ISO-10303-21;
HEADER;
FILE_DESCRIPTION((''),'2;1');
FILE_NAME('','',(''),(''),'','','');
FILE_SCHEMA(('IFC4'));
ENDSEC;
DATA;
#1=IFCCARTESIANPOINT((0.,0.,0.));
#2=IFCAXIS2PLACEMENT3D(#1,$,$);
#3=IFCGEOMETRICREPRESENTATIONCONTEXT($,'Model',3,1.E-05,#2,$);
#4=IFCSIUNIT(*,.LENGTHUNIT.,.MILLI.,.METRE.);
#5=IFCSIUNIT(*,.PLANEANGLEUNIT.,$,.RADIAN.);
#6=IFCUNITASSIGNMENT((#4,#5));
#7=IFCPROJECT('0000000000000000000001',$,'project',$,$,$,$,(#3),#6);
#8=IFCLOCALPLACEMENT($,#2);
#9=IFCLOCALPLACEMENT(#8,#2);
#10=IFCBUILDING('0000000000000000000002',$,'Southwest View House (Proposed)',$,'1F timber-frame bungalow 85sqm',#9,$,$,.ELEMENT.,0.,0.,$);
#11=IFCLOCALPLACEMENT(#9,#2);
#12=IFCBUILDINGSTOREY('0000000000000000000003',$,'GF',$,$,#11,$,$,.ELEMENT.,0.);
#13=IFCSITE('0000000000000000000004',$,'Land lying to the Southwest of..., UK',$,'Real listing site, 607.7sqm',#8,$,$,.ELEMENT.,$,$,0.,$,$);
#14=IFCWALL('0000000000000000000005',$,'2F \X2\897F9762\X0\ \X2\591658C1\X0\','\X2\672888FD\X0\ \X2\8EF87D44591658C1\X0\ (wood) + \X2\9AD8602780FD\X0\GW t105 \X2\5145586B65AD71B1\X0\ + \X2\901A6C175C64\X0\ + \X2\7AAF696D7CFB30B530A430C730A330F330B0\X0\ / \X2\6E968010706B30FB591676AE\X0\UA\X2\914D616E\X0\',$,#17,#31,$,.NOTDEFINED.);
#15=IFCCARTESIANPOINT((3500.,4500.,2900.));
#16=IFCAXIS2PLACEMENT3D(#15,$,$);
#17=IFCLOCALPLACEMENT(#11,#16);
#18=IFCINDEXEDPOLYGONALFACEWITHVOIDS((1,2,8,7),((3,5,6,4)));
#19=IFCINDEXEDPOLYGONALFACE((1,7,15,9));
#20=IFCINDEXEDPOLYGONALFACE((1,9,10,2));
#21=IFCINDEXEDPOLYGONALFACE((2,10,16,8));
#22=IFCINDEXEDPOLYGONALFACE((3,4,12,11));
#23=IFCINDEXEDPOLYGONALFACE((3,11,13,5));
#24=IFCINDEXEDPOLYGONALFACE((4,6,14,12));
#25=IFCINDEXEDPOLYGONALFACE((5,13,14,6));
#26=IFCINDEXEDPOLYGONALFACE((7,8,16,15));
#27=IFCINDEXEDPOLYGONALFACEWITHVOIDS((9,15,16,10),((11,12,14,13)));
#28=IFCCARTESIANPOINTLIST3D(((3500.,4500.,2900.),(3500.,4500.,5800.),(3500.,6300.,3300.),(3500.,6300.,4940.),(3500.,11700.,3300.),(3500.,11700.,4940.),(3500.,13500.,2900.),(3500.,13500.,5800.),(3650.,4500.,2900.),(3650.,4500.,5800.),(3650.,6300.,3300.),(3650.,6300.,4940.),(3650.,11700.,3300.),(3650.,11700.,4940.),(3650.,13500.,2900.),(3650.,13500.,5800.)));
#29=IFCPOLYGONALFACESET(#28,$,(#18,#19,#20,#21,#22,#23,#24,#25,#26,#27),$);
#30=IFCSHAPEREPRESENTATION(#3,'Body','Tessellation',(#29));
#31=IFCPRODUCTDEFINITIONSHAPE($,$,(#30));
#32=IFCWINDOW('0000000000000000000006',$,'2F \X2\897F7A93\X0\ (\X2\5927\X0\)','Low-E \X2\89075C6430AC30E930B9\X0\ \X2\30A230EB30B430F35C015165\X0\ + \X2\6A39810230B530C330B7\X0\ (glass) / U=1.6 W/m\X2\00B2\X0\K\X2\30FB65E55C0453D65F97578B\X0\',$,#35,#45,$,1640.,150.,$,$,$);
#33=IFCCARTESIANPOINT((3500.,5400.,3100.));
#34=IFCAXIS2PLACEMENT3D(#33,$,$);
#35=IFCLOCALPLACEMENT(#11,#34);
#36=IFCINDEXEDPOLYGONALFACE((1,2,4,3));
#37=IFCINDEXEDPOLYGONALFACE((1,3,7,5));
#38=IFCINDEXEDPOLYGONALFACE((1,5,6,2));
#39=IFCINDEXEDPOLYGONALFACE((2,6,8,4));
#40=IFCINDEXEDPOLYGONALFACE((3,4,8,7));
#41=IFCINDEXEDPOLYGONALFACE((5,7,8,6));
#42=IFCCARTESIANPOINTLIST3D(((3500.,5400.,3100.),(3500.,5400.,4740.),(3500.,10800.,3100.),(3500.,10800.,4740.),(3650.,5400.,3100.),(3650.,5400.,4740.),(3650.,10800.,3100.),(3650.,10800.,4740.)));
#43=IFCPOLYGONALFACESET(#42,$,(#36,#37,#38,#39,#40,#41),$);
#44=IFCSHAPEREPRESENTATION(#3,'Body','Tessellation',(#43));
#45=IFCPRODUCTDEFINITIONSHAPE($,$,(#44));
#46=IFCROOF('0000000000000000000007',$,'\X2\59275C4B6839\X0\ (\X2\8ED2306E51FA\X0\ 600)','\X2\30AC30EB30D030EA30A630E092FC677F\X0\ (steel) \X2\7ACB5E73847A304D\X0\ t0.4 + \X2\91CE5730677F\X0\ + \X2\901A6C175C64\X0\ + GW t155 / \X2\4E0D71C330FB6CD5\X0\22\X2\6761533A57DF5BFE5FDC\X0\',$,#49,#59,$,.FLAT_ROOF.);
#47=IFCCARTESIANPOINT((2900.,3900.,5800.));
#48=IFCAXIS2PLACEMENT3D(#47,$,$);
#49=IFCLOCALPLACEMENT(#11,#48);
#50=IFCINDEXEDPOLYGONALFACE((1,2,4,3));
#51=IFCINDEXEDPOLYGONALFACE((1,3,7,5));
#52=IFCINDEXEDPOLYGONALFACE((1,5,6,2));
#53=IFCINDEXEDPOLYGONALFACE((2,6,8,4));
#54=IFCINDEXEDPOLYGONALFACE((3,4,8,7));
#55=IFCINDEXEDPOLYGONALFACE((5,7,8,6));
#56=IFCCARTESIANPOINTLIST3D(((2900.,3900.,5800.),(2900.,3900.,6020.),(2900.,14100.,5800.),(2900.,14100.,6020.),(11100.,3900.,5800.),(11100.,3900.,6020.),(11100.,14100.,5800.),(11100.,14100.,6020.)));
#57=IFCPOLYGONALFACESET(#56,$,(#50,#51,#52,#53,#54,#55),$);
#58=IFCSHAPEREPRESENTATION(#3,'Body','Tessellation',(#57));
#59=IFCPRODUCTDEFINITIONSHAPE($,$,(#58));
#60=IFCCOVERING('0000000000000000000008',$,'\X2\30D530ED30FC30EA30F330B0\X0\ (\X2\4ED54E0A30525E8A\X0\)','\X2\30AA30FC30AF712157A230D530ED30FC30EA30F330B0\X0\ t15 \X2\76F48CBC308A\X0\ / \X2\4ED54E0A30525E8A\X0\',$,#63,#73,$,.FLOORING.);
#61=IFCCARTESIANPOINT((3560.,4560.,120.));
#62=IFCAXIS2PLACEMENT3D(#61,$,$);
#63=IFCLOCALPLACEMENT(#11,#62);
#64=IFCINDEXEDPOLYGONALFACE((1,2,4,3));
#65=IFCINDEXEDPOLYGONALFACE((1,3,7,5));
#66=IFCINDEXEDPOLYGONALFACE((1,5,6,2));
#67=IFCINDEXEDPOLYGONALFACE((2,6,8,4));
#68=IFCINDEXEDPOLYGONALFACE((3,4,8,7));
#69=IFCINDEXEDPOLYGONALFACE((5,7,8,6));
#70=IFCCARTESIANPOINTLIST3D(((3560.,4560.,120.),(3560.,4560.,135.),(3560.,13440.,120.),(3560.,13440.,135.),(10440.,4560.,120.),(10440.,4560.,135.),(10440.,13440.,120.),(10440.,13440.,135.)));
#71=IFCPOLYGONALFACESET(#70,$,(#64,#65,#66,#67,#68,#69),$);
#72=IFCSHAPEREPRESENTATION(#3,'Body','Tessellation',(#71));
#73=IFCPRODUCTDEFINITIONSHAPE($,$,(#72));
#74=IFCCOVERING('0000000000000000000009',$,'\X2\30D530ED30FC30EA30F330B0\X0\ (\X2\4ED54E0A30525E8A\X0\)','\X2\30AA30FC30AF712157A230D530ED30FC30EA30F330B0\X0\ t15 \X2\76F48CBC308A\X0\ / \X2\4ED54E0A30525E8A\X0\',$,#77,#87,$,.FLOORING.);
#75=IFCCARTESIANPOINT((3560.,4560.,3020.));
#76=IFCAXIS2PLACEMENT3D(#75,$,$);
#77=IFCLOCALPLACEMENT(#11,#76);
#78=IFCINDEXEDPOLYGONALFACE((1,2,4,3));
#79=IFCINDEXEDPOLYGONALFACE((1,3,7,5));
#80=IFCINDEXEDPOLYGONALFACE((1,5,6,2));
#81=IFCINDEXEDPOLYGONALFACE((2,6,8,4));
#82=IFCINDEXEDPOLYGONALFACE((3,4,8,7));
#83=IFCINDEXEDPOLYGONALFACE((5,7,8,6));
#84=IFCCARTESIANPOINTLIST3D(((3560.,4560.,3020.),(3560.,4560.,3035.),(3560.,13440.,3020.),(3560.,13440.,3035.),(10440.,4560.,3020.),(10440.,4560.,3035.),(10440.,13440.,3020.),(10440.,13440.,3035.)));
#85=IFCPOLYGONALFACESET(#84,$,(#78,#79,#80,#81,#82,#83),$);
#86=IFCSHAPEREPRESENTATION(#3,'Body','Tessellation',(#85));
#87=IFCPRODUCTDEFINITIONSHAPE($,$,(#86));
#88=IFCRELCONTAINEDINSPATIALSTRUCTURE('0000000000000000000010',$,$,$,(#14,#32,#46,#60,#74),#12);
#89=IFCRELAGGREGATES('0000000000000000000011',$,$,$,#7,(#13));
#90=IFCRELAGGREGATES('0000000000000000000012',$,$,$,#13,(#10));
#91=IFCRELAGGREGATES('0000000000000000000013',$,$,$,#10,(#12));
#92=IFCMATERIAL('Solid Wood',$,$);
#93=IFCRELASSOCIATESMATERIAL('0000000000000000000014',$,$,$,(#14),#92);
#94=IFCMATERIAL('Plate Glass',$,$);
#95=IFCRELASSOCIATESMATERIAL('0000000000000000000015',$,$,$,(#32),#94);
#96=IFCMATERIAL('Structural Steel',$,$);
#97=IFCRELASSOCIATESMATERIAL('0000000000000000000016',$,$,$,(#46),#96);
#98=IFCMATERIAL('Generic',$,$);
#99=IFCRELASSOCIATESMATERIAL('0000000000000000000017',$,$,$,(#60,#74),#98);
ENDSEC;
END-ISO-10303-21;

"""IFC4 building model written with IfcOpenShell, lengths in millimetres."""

from ifc_helpers import new_model, si_unit, frame, frame_2d, origin, place, context, project, spatial, rectangle, extrude, material, element, fill, save


model = new_model("IFC4")

# Units and contexts
model_context = context("Model", 3, precision=1e-05, world=origin())
ifc_project = project(units=[si_unit("LENGTHUNIT", "METRE", prefix="MILLI"), si_unit("PLANEANGLEUNIT", "RADIAN")], contexts=[model_context])

# Site, building, storey
site_placement = place(None, origin())
site = spatial("IfcSite", under=ifc_project, at=site_placement, Name="Land lying to the Southwest of..., UK", ObjectType="Real listing site, 607.7sqm", CompositionType="ELEMENT", RefElevation=0.0)
building_placement = place(site_placement, origin())
building = spatial("IfcBuilding", under=site, at=building_placement, Name="Southwest View House (Proposed)", ObjectType="1F timber-frame bungalow 85sqm", CompositionType="ELEMENT", ElevationOfRefHeight=0.0, ElevationOfTerrain=0.0)
storey_placement = place(building_placement, origin())
storey = spatial("IfcBuildingStorey", under=building, at=storey_placement, Name="GF", CompositionType="ELEMENT", Elevation=0.0)

# Shared definitions
ifc_material_1 = material(Name="Solid Wood")
ifc_material_2 = material(Name="Generic")

# Shared definitions
ifc_material_3 = material(Name="Plate Glass")

# Wall, opening, window
wall_1_placement = place(storey_placement, frame((3500.0, 4500.0, 2900.0)))
wall_1 = element("IfcWall", 1, at=wall_1_placement, inside=storey, material=ifc_material_1, Name="2F 西面 外壁", Description="木製 軸組外壁 (wood) + 高性能GW t105 充填断熱 + 通気層 + 窯業系サイディング / 準耐火・外皮UA配慮", PredefinedType="NOTDEFINED", context=model_context, shape_type="SweptSolid", body=[
    extrude(rectangle(XDim=150.0, YDim=9000.0, at=frame_2d((75.0, 4500.0))), frame((3500.0, 4500.0, 2900.0)), (0.0, 0.0, 1.0), 2900.0),
])
opening_1_placement = place(storey_placement, frame((3500.0, 5400.0, 3100.0)))
opening_1 = element("IfcOpeningElement", 2, at=opening_1_placement, cuts=wall_1, PredefinedType="NOTDEFINED", context=model_context, shape_type="SweptSolid", body=[
    extrude(rectangle(XDim=150.0, YDim=5400.0, at=frame_2d((75.0, 2700.0))), frame((3500.0, 5400.0, 3100.0)), (0.0, 0.0, 1.0), 1640.0),
])
window_1_placement = place(storey_placement, frame((3500.0, 5400.0, 3100.0)))
window_1 = element("IfcWindow", 3, at=window_1_placement, inside=storey, material=ifc_material_3, Name="2F 西窓 (大)", Description="Low-E 複層ガラス アルゴン封入 + 樹脂サッシ (glass) / U=1.6 W/m²K・日射取得型", OverallHeight=1640.0, OverallWidth=150.0, context=model_context, shape_type="SweptSolid", body=[
    extrude(rectangle(XDim=150.0, YDim=5400.0, at=frame_2d((75.0, 2700.0))), frame((3500.0, 5400.0, 3100.0)), (0.0, 0.0, 1.0), 1640.0),
])
fill(opening_1, window_1)

# Roof
ifc_material_4 = material(Name="Structural Steel")
roof_placement = place(storey_placement, frame((2900.0, 3900.0, 5800.0)))
element("IfcRoof", 4, at=roof_placement, inside=storey, material=ifc_material_4, Name="大屋根 (軒の出 600)", Description="ガルバリウム鋼板 (steel) 立平葺き t0.4 + 野地板 + 通気層 + GW t155 / 不燃・法22条区域対応", PredefinedType="FLAT_ROOF", context=model_context, shape_type="SweptSolid", body=[
    extrude(rectangle(XDim=8200.0, YDim=10200.0, at=frame_2d((4100.0, 5100.0))), frame((2900.0, 3900.0, 5800.0)), (0.0, 0.0, 1.0), 220.0),
])

# Coverings
covering_1_placement = place(storey_placement, frame((3560.0, 4560.0, 120.0)))
element("IfcCovering", 5, at=covering_1_placement, inside=storey, material=ifc_material_2, Name="フローリング (仕上げ床)", Description="オーク無垢フローリング t15 直貼り / 仕上げ床", PredefinedType="FLOORING", context=model_context, shape_type="SweptSolid", body=[
    extrude(rectangle(XDim=6880.0, YDim=8880.0, at=frame_2d((3440.0, 4440.0))), frame((3560.0, 4560.0, 120.0)), (0.0, 0.0, 1.0), 15.0),
])
covering_2_placement = place(storey_placement, frame((3560.0, 4560.0, 3020.0)))
element("IfcCovering", 6, at=covering_2_placement, inside=storey, material=ifc_material_2, Name="フローリング (仕上げ床)", Description="オーク無垢フローリング t15 直貼り / 仕上げ床", PredefinedType="FLOORING", context=model_context, shape_type="SweptSolid", body=[
    extrude(rectangle(XDim=6880.0, YDim=8880.0, at=frame_2d((3440.0, 4440.0))), frame((3560.0, 4560.0, 3020.0)), (0.0, 0.0, 1.0), 15.0),
])

save(model, "model.ifc")
